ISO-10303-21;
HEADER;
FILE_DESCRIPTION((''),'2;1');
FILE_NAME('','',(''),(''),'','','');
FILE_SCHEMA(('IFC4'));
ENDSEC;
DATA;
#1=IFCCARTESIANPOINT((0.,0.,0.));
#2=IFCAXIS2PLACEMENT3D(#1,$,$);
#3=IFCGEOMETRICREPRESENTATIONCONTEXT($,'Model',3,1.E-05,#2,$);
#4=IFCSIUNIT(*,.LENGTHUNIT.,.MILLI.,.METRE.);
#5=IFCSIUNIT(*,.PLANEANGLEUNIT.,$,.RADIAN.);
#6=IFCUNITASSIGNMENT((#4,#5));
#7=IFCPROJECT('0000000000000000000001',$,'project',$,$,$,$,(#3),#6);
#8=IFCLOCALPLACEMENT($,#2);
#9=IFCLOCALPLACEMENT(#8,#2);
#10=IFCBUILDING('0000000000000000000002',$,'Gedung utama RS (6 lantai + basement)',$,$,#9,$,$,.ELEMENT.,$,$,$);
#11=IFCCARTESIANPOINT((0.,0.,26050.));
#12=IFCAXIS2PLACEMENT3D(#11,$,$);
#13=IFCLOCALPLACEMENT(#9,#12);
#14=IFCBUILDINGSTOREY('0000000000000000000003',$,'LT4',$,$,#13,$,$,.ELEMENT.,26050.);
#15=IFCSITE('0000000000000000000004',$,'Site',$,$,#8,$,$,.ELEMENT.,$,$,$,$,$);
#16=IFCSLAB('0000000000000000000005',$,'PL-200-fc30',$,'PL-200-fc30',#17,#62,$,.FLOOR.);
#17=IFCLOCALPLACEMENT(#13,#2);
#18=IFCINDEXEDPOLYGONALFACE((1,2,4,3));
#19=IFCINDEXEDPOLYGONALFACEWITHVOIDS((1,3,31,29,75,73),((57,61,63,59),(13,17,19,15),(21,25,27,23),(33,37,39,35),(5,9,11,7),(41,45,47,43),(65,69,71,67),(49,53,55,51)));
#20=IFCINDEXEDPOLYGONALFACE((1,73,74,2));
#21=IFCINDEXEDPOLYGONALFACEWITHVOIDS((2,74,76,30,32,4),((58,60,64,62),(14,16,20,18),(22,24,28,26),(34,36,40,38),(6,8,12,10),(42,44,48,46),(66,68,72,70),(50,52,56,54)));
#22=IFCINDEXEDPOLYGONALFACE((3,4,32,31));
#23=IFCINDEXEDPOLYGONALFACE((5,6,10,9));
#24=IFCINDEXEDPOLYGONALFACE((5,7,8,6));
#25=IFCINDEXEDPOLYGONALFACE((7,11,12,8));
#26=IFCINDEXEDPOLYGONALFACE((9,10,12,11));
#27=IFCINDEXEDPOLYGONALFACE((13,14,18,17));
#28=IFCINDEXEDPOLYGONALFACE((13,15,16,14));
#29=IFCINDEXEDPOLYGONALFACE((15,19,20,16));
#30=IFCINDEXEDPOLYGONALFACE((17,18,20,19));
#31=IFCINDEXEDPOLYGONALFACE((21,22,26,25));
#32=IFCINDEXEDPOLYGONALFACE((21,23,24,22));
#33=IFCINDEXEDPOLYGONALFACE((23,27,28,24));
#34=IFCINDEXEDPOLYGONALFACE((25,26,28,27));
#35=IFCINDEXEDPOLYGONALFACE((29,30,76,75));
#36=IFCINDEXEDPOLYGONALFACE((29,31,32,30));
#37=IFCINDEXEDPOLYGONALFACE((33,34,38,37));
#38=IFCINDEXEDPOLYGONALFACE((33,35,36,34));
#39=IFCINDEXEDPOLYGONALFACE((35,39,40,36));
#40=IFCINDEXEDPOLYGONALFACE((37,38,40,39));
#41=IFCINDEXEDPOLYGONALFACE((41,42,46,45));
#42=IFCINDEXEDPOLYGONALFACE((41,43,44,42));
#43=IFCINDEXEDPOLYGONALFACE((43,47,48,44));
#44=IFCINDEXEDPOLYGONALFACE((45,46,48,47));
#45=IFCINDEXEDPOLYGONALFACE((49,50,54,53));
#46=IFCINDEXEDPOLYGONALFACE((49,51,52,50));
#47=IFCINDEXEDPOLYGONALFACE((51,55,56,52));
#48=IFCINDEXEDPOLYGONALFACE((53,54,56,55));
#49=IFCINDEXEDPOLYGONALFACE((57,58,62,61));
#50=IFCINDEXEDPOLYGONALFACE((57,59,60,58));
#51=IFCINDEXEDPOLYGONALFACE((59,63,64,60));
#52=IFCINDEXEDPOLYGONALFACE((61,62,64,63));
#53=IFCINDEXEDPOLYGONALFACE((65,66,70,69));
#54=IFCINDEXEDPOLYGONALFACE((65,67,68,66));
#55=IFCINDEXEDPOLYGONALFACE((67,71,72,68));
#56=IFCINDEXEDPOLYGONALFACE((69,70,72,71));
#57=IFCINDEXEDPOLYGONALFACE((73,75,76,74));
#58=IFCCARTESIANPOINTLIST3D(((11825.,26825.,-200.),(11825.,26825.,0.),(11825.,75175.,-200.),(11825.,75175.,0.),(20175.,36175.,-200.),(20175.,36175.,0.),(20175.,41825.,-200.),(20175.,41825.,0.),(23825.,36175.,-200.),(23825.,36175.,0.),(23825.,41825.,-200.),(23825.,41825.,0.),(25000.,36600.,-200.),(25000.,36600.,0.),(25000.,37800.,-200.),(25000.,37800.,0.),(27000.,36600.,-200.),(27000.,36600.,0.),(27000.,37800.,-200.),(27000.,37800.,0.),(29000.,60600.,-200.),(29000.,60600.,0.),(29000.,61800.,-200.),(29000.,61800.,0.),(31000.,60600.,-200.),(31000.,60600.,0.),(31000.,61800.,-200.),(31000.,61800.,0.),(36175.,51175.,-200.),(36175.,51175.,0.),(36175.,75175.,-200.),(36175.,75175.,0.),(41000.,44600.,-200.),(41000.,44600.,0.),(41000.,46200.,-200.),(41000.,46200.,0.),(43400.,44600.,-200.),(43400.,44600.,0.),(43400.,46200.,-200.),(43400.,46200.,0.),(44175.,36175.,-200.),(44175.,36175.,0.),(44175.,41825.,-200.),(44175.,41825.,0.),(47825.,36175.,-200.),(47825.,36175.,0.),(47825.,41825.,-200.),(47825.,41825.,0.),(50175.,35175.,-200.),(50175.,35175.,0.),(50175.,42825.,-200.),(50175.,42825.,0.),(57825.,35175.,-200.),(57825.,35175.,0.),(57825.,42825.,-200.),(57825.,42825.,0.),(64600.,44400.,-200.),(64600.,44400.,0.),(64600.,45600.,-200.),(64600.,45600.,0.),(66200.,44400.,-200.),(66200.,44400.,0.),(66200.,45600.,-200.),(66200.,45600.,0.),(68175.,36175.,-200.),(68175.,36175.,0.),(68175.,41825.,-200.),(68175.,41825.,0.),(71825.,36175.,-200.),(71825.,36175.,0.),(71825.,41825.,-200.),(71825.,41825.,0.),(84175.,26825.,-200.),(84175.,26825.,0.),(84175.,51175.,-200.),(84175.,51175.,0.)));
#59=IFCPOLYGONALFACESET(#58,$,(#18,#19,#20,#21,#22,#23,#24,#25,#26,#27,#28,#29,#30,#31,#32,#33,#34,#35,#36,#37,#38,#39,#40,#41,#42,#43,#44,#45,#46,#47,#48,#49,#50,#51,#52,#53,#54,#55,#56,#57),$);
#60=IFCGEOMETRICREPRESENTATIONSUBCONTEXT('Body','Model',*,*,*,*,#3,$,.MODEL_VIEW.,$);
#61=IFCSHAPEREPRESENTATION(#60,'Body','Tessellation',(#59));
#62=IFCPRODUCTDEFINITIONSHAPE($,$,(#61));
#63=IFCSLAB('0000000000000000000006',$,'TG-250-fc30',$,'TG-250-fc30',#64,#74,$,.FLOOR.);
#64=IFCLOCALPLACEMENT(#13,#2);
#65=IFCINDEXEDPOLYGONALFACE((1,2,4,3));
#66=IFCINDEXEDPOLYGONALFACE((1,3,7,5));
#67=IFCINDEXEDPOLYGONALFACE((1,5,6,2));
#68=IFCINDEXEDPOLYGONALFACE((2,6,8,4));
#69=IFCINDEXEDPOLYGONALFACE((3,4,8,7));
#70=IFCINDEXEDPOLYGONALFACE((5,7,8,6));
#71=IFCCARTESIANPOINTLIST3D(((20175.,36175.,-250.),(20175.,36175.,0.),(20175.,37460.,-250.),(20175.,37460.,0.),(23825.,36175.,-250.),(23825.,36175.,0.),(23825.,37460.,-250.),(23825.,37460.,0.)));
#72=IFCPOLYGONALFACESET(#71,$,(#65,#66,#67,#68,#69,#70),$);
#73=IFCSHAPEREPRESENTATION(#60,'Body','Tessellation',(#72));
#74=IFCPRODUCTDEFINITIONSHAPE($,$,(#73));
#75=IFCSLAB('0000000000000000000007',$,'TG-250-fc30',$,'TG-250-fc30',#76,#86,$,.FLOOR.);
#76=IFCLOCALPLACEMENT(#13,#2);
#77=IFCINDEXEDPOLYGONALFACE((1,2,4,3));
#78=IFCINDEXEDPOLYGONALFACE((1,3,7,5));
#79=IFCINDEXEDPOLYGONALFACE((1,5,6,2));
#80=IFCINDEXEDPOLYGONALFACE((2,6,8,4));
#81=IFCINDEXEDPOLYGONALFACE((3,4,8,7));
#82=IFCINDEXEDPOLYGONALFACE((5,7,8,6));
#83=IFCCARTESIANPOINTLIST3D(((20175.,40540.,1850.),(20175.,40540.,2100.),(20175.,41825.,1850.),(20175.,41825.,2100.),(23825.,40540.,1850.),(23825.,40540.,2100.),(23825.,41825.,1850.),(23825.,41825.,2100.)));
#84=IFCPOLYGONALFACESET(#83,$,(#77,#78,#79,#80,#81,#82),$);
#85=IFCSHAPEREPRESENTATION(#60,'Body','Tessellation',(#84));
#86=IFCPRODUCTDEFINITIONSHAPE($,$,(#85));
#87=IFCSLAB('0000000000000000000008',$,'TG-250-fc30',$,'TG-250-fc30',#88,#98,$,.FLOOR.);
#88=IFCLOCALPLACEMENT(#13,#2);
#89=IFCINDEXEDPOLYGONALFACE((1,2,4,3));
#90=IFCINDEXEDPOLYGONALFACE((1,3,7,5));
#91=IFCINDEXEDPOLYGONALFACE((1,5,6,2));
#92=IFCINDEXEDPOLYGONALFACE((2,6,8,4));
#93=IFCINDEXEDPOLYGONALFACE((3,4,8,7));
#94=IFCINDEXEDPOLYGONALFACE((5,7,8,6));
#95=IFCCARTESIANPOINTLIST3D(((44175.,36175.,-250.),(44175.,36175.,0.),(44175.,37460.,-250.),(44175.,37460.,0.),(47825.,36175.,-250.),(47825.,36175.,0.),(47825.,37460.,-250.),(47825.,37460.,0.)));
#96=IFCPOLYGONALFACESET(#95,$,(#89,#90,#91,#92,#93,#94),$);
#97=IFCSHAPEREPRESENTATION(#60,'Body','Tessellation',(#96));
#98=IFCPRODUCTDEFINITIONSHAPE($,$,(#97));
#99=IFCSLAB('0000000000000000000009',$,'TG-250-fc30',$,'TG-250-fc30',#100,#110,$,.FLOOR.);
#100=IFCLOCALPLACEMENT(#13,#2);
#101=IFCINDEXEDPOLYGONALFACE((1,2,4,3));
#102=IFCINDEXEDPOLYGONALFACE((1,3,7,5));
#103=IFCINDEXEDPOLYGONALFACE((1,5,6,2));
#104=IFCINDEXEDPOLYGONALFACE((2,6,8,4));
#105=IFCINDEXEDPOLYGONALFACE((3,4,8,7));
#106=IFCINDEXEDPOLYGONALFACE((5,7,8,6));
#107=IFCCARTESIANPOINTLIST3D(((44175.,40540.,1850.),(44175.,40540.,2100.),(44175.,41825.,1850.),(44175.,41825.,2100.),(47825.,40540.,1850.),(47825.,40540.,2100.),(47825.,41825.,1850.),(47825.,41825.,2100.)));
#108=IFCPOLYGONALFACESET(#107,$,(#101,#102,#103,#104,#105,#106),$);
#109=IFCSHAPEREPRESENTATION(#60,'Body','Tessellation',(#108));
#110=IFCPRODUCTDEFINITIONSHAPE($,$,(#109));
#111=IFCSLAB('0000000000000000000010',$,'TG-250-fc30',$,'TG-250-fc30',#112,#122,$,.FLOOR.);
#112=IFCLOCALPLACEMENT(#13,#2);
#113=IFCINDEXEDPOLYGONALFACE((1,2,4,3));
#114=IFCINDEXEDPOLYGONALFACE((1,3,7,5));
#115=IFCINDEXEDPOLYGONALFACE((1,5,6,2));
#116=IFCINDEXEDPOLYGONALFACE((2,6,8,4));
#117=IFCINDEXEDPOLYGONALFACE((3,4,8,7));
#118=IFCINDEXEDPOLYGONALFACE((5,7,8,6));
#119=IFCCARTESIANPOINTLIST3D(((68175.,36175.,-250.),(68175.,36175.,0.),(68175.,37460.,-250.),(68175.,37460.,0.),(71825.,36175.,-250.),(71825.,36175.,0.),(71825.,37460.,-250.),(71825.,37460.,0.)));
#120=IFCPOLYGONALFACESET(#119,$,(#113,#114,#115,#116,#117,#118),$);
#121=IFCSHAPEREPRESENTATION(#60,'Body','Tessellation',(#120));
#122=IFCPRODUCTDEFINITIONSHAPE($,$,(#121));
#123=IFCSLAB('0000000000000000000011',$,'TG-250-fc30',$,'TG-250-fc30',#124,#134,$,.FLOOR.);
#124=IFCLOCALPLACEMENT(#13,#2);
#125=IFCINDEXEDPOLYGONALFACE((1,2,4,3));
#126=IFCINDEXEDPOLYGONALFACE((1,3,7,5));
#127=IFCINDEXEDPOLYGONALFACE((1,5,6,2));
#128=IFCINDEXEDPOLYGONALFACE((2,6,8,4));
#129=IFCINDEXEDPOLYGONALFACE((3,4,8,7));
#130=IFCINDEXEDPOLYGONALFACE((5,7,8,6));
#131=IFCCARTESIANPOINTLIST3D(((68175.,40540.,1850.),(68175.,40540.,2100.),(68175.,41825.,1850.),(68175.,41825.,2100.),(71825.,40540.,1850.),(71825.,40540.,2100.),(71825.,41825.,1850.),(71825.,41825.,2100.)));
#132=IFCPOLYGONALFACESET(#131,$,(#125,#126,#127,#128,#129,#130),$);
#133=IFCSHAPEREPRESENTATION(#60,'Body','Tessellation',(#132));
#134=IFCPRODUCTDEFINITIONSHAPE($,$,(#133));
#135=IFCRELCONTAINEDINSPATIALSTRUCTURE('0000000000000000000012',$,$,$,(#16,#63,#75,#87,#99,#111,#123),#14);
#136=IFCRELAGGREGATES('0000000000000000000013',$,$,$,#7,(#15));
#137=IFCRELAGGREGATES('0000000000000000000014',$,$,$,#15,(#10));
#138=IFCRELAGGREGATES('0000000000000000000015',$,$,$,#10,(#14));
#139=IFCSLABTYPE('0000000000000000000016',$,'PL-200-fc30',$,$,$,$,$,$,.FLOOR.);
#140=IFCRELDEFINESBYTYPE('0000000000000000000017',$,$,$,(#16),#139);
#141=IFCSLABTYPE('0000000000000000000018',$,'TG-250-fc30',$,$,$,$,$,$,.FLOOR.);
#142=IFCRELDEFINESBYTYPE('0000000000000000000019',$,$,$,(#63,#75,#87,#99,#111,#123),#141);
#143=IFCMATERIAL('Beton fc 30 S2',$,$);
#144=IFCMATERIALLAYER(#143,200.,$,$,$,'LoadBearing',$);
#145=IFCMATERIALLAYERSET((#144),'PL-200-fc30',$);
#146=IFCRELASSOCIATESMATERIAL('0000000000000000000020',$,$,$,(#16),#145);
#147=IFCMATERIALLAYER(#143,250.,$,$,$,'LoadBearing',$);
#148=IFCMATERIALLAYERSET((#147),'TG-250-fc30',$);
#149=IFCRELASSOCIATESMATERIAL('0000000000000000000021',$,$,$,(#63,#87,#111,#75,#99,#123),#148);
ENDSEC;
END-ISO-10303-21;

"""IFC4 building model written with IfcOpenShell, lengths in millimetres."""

from ifc_helpers import new_model, si_unit, frame, origin, place, context, subcontext, project, spatial, polyline, outline, extrude, material, layer, layer_set, layer_usage, type_object, element, save


model = new_model("IFC4")

# Units and contexts
model_context = context("Model", 3, precision=1e-05, world=origin())
body_context = subcontext(model_context, "Body", "Model", "MODEL_VIEW")
ifc_project = project(units=[si_unit("LENGTHUNIT", "METRE", prefix="MILLI"), si_unit("PLANEANGLEUNIT", "RADIAN")], contexts=[model_context])

# Site, building, storey
site_placement = place(None, origin())
site = spatial("IfcSite", under=ifc_project, at=site_placement, Name="Site", CompositionType="ELEMENT")
building_placement = place(site_placement, origin())
building = spatial("IfcBuilding", under=site, at=building_placement, Name="Gedung utama RS (6 lantai + basement)", CompositionType="ELEMENT")
storey_placement = place(building_placement, frame((0.0, 0.0, 26050.0)))
storey = spatial("IfcBuildingStorey", under=building, at=storey_placement, Name="LT4", CompositionType="ELEMENT", Elevation=26050.0)

# Shared definitions
ifc_material = material(Name="Beton fc 30 S2")

# Slab, openings
ifc_layer_1 = layer(ifc_material, 200.0, Category="LoadBearing")
ifc_layer_set_1 = layer_set([ifc_layer_1], Name="PL-200-fc30")
ifc_layer_usage_1 = layer_usage(ifc_layer_set_1, "AXIS3", "NEGATIVE", 0.0)
slab_type_1 = type_object("IfcSlabType", Name="PL-200-fc30", PredefinedType="FLOOR")
slab_1_placement = place(storey_placement, origin())
slab_1 = element("IfcSlab", 1, at=slab_1_placement, inside=storey, type_object=slab_type_1, material=ifc_layer_usage_1, Name="PL-200-fc30", ObjectType="PL-200-fc30", PredefinedType="FLOOR", context=body_context, shape_type="SweptSolid", body=[
    extrude(outline(polyline([(36175.0, 51175.0), (36175.0, 75175.0), (11825.0, 75175.0), (11825.0, 26825.0), (84175.0, 26825.0), (84175.0, 51175.0), (36175.0, 51175.0)]), holes=[polyline([(23825.0, 36175.0), (23825.0, 41825.0), (20175.0, 41825.0), (20175.0, 36175.0), (23825.0, 36175.0)]), polyline([(47825.0, 36175.0), (47825.0, 41825.0), (44175.0, 41825.0), (44175.0, 36175.0), (47825.0, 36175.0)]), polyline([(71825.0, 36175.0), (71825.0, 41825.0), (68175.0, 41825.0), (68175.0, 36175.0), (71825.0, 36175.0)])]), frame((0.0, 0.0, -200.0)), (0.0, 0.0, 1.0), 200.0),
])
opening_1_placement = place(slab_1_placement, frame((0.0, 0.0, -13100.0)))
element("IfcOpeningElement", 2, at=opening_1_placement, cuts=slab_1, PredefinedType="OPENING", context=body_context, shape_type="SweptSolid", body=[
    extrude(outline(polyline([(27000.0, 36600.0), (27000.0, 37800.0), (25000.0, 37800.0), (25000.0, 36600.0), (27000.0, 36600.0)])), origin(), (0.0, 0.0, 1.0), 25800.0),
])
opening_2_placement = place(slab_1_placement, frame((0.0, 0.0, -13100.0)))
element("IfcOpeningElement", 3, at=opening_2_placement, cuts=slab_1, PredefinedType="OPENING", context=body_context, shape_type="SweptSolid", body=[
    extrude(outline(polyline([(43400.0, 44600.0), (43400.0, 46200.0), (41000.0, 46200.0), (41000.0, 44600.0), (43400.0, 44600.0)])), origin(), (0.0, 0.0, 1.0), 25800.0),
])
opening_3_placement = place(slab_1_placement, frame((0.0, 0.0, -13100.0)))
element("IfcOpeningElement", 4, at=opening_3_placement, cuts=slab_1, PredefinedType="OPENING", context=body_context, shape_type="SweptSolid", body=[
    extrude(outline(polyline([(66200.0, 44400.0), (66200.0, 45600.0), (64600.0, 45600.0), (64600.0, 44400.0), (66200.0, 44400.0)])), origin(), (0.0, 0.0, 1.0), 25800.0),
])
opening_4_placement = place(slab_1_placement, frame((0.0, 0.0, -13100.0)))
element("IfcOpeningElement", 5, at=opening_4_placement, cuts=slab_1, PredefinedType="OPENING", context=body_context, shape_type="SweptSolid", body=[
    extrude(outline(polyline([(31000.0, 60600.0), (31000.0, 61800.0), (29000.0, 61800.0), (29000.0, 60600.0), (31000.0, 60600.0)])), origin(), (0.0, 0.0, 1.0), 13200.0),
])
opening_5_placement = place(slab_1_placement, frame((0.0, 0.0, -13100.0)))
element("IfcOpeningElement", 6, at=opening_5_placement, cuts=slab_1, PredefinedType="OPENING", context=body_context, shape_type="SweptSolid", body=[
    extrude(outline(polyline([(57825.0, 35175.0), (57825.0, 42825.0), (50175.0, 42825.0), (50175.0, 35175.0), (57825.0, 35175.0)])), origin(), (0.0, 0.0, 1.0), 21600.0),
])

# Slabs
ifc_layer_2 = layer(ifc_material, 250.0, Category="LoadBearing")
ifc_layer_set_2 = layer_set([ifc_layer_2], Name="TG-250-fc30")
ifc_layer_usage_2 = layer_usage(ifc_layer_set_2, "AXIS3", "NEGATIVE", 0.0)
slab_type_2 = type_object("IfcSlabType", Name="TG-250-fc30", PredefinedType="FLOOR")
slab_2_placement = place(storey_placement, origin())
element("IfcSlab", 7, at=slab_2_placement, inside=storey, type_object=slab_type_2, material=ifc_layer_usage_2, Name="TG-250-fc30", ObjectType="TG-250-fc30", PredefinedType="FLOOR", context=body_context, shape_type="SweptSolid", body=[
    extrude(outline(polyline([(23825.0, 36175.0), (23825.0, 37460.0), (20175.0, 37460.0), (20175.0, 36175.0), (23825.0, 36175.0)])), frame((0.0, 0.0, -250.0)), (0.0, 0.0, 1.0), 250.0),
])
ifc_layer_usage_3 = layer_usage(ifc_layer_set_2, "AXIS3", "NEGATIVE", 2100.0)
slab_3_placement = place(storey_placement, origin())
element("IfcSlab", 8, at=slab_3_placement, inside=storey, type_object=slab_type_2, material=ifc_layer_usage_3, Name="TG-250-fc30", ObjectType="TG-250-fc30", PredefinedType="FLOOR", context=body_context, shape_type="SweptSolid", body=[
    extrude(outline(polyline([(23825.0, 40540.0), (23825.0, 41825.0), (20175.0, 41825.0), (20175.0, 40540.0), (23825.0, 40540.0)])), frame((0.0, 0.0, 1850.0)), (0.0, 0.0, 1.0), 250.0),
])
slab_4_placement = place(storey_placement, origin())
element("IfcSlab", 9, at=slab_4_placement, inside=storey, type_object=slab_type_2, material=ifc_layer_usage_2, Name="TG-250-fc30", ObjectType="TG-250-fc30", PredefinedType="FLOOR", context=body_context, shape_type="SweptSolid", body=[
    extrude(outline(polyline([(47825.0, 36175.0), (47825.0, 37460.0), (44175.0, 37460.0), (44175.0, 36175.0), (47825.0, 36175.0)])), frame((0.0, 0.0, -250.0)), (0.0, 0.0, 1.0), 250.0),
])
slab_5_placement = place(storey_placement, origin())
element("IfcSlab", 10, at=slab_5_placement, inside=storey, type_object=slab_type_2, material=ifc_layer_usage_3, Name="TG-250-fc30", ObjectType="TG-250-fc30", PredefinedType="FLOOR", context=body_context, shape_type="SweptSolid", body=[
    extrude(outline(polyline([(47825.0, 40540.0), (47825.0, 41825.0), (44175.0, 41825.0), (44175.0, 40540.0), (47825.0, 40540.0)])), frame((0.0, 0.0, 1850.0)), (0.0, 0.0, 1.0), 250.0),
])
slab_6_placement = place(storey_placement, origin())
element("IfcSlab", 11, at=slab_6_placement, inside=storey, type_object=slab_type_2, material=ifc_layer_usage_2, Name="TG-250-fc30", ObjectType="TG-250-fc30", PredefinedType="FLOOR", context=body_context, shape_type="SweptSolid", body=[
    extrude(outline(polyline([(71825.0, 36175.0), (71825.0, 37460.0), (68175.0, 37460.0), (68175.0, 36175.0), (71825.0, 36175.0)])), frame((0.0, 0.0, -250.0)), (0.0, 0.0, 1.0), 250.0),
])
slab_7_placement = place(storey_placement, origin())
element("IfcSlab", 12, at=slab_7_placement, inside=storey, type_object=slab_type_2, material=ifc_layer_usage_3, Name="TG-250-fc30", ObjectType="TG-250-fc30", PredefinedType="FLOOR", context=body_context, shape_type="SweptSolid", body=[
    extrude(outline(polyline([(71825.0, 40540.0), (71825.0, 41825.0), (68175.0, 41825.0), (68175.0, 40540.0), (71825.0, 40540.0)])), frame((0.0, 0.0, 1850.0)), (0.0, 0.0, 1.0), 250.0),
])

save(model, "model.ifc")
